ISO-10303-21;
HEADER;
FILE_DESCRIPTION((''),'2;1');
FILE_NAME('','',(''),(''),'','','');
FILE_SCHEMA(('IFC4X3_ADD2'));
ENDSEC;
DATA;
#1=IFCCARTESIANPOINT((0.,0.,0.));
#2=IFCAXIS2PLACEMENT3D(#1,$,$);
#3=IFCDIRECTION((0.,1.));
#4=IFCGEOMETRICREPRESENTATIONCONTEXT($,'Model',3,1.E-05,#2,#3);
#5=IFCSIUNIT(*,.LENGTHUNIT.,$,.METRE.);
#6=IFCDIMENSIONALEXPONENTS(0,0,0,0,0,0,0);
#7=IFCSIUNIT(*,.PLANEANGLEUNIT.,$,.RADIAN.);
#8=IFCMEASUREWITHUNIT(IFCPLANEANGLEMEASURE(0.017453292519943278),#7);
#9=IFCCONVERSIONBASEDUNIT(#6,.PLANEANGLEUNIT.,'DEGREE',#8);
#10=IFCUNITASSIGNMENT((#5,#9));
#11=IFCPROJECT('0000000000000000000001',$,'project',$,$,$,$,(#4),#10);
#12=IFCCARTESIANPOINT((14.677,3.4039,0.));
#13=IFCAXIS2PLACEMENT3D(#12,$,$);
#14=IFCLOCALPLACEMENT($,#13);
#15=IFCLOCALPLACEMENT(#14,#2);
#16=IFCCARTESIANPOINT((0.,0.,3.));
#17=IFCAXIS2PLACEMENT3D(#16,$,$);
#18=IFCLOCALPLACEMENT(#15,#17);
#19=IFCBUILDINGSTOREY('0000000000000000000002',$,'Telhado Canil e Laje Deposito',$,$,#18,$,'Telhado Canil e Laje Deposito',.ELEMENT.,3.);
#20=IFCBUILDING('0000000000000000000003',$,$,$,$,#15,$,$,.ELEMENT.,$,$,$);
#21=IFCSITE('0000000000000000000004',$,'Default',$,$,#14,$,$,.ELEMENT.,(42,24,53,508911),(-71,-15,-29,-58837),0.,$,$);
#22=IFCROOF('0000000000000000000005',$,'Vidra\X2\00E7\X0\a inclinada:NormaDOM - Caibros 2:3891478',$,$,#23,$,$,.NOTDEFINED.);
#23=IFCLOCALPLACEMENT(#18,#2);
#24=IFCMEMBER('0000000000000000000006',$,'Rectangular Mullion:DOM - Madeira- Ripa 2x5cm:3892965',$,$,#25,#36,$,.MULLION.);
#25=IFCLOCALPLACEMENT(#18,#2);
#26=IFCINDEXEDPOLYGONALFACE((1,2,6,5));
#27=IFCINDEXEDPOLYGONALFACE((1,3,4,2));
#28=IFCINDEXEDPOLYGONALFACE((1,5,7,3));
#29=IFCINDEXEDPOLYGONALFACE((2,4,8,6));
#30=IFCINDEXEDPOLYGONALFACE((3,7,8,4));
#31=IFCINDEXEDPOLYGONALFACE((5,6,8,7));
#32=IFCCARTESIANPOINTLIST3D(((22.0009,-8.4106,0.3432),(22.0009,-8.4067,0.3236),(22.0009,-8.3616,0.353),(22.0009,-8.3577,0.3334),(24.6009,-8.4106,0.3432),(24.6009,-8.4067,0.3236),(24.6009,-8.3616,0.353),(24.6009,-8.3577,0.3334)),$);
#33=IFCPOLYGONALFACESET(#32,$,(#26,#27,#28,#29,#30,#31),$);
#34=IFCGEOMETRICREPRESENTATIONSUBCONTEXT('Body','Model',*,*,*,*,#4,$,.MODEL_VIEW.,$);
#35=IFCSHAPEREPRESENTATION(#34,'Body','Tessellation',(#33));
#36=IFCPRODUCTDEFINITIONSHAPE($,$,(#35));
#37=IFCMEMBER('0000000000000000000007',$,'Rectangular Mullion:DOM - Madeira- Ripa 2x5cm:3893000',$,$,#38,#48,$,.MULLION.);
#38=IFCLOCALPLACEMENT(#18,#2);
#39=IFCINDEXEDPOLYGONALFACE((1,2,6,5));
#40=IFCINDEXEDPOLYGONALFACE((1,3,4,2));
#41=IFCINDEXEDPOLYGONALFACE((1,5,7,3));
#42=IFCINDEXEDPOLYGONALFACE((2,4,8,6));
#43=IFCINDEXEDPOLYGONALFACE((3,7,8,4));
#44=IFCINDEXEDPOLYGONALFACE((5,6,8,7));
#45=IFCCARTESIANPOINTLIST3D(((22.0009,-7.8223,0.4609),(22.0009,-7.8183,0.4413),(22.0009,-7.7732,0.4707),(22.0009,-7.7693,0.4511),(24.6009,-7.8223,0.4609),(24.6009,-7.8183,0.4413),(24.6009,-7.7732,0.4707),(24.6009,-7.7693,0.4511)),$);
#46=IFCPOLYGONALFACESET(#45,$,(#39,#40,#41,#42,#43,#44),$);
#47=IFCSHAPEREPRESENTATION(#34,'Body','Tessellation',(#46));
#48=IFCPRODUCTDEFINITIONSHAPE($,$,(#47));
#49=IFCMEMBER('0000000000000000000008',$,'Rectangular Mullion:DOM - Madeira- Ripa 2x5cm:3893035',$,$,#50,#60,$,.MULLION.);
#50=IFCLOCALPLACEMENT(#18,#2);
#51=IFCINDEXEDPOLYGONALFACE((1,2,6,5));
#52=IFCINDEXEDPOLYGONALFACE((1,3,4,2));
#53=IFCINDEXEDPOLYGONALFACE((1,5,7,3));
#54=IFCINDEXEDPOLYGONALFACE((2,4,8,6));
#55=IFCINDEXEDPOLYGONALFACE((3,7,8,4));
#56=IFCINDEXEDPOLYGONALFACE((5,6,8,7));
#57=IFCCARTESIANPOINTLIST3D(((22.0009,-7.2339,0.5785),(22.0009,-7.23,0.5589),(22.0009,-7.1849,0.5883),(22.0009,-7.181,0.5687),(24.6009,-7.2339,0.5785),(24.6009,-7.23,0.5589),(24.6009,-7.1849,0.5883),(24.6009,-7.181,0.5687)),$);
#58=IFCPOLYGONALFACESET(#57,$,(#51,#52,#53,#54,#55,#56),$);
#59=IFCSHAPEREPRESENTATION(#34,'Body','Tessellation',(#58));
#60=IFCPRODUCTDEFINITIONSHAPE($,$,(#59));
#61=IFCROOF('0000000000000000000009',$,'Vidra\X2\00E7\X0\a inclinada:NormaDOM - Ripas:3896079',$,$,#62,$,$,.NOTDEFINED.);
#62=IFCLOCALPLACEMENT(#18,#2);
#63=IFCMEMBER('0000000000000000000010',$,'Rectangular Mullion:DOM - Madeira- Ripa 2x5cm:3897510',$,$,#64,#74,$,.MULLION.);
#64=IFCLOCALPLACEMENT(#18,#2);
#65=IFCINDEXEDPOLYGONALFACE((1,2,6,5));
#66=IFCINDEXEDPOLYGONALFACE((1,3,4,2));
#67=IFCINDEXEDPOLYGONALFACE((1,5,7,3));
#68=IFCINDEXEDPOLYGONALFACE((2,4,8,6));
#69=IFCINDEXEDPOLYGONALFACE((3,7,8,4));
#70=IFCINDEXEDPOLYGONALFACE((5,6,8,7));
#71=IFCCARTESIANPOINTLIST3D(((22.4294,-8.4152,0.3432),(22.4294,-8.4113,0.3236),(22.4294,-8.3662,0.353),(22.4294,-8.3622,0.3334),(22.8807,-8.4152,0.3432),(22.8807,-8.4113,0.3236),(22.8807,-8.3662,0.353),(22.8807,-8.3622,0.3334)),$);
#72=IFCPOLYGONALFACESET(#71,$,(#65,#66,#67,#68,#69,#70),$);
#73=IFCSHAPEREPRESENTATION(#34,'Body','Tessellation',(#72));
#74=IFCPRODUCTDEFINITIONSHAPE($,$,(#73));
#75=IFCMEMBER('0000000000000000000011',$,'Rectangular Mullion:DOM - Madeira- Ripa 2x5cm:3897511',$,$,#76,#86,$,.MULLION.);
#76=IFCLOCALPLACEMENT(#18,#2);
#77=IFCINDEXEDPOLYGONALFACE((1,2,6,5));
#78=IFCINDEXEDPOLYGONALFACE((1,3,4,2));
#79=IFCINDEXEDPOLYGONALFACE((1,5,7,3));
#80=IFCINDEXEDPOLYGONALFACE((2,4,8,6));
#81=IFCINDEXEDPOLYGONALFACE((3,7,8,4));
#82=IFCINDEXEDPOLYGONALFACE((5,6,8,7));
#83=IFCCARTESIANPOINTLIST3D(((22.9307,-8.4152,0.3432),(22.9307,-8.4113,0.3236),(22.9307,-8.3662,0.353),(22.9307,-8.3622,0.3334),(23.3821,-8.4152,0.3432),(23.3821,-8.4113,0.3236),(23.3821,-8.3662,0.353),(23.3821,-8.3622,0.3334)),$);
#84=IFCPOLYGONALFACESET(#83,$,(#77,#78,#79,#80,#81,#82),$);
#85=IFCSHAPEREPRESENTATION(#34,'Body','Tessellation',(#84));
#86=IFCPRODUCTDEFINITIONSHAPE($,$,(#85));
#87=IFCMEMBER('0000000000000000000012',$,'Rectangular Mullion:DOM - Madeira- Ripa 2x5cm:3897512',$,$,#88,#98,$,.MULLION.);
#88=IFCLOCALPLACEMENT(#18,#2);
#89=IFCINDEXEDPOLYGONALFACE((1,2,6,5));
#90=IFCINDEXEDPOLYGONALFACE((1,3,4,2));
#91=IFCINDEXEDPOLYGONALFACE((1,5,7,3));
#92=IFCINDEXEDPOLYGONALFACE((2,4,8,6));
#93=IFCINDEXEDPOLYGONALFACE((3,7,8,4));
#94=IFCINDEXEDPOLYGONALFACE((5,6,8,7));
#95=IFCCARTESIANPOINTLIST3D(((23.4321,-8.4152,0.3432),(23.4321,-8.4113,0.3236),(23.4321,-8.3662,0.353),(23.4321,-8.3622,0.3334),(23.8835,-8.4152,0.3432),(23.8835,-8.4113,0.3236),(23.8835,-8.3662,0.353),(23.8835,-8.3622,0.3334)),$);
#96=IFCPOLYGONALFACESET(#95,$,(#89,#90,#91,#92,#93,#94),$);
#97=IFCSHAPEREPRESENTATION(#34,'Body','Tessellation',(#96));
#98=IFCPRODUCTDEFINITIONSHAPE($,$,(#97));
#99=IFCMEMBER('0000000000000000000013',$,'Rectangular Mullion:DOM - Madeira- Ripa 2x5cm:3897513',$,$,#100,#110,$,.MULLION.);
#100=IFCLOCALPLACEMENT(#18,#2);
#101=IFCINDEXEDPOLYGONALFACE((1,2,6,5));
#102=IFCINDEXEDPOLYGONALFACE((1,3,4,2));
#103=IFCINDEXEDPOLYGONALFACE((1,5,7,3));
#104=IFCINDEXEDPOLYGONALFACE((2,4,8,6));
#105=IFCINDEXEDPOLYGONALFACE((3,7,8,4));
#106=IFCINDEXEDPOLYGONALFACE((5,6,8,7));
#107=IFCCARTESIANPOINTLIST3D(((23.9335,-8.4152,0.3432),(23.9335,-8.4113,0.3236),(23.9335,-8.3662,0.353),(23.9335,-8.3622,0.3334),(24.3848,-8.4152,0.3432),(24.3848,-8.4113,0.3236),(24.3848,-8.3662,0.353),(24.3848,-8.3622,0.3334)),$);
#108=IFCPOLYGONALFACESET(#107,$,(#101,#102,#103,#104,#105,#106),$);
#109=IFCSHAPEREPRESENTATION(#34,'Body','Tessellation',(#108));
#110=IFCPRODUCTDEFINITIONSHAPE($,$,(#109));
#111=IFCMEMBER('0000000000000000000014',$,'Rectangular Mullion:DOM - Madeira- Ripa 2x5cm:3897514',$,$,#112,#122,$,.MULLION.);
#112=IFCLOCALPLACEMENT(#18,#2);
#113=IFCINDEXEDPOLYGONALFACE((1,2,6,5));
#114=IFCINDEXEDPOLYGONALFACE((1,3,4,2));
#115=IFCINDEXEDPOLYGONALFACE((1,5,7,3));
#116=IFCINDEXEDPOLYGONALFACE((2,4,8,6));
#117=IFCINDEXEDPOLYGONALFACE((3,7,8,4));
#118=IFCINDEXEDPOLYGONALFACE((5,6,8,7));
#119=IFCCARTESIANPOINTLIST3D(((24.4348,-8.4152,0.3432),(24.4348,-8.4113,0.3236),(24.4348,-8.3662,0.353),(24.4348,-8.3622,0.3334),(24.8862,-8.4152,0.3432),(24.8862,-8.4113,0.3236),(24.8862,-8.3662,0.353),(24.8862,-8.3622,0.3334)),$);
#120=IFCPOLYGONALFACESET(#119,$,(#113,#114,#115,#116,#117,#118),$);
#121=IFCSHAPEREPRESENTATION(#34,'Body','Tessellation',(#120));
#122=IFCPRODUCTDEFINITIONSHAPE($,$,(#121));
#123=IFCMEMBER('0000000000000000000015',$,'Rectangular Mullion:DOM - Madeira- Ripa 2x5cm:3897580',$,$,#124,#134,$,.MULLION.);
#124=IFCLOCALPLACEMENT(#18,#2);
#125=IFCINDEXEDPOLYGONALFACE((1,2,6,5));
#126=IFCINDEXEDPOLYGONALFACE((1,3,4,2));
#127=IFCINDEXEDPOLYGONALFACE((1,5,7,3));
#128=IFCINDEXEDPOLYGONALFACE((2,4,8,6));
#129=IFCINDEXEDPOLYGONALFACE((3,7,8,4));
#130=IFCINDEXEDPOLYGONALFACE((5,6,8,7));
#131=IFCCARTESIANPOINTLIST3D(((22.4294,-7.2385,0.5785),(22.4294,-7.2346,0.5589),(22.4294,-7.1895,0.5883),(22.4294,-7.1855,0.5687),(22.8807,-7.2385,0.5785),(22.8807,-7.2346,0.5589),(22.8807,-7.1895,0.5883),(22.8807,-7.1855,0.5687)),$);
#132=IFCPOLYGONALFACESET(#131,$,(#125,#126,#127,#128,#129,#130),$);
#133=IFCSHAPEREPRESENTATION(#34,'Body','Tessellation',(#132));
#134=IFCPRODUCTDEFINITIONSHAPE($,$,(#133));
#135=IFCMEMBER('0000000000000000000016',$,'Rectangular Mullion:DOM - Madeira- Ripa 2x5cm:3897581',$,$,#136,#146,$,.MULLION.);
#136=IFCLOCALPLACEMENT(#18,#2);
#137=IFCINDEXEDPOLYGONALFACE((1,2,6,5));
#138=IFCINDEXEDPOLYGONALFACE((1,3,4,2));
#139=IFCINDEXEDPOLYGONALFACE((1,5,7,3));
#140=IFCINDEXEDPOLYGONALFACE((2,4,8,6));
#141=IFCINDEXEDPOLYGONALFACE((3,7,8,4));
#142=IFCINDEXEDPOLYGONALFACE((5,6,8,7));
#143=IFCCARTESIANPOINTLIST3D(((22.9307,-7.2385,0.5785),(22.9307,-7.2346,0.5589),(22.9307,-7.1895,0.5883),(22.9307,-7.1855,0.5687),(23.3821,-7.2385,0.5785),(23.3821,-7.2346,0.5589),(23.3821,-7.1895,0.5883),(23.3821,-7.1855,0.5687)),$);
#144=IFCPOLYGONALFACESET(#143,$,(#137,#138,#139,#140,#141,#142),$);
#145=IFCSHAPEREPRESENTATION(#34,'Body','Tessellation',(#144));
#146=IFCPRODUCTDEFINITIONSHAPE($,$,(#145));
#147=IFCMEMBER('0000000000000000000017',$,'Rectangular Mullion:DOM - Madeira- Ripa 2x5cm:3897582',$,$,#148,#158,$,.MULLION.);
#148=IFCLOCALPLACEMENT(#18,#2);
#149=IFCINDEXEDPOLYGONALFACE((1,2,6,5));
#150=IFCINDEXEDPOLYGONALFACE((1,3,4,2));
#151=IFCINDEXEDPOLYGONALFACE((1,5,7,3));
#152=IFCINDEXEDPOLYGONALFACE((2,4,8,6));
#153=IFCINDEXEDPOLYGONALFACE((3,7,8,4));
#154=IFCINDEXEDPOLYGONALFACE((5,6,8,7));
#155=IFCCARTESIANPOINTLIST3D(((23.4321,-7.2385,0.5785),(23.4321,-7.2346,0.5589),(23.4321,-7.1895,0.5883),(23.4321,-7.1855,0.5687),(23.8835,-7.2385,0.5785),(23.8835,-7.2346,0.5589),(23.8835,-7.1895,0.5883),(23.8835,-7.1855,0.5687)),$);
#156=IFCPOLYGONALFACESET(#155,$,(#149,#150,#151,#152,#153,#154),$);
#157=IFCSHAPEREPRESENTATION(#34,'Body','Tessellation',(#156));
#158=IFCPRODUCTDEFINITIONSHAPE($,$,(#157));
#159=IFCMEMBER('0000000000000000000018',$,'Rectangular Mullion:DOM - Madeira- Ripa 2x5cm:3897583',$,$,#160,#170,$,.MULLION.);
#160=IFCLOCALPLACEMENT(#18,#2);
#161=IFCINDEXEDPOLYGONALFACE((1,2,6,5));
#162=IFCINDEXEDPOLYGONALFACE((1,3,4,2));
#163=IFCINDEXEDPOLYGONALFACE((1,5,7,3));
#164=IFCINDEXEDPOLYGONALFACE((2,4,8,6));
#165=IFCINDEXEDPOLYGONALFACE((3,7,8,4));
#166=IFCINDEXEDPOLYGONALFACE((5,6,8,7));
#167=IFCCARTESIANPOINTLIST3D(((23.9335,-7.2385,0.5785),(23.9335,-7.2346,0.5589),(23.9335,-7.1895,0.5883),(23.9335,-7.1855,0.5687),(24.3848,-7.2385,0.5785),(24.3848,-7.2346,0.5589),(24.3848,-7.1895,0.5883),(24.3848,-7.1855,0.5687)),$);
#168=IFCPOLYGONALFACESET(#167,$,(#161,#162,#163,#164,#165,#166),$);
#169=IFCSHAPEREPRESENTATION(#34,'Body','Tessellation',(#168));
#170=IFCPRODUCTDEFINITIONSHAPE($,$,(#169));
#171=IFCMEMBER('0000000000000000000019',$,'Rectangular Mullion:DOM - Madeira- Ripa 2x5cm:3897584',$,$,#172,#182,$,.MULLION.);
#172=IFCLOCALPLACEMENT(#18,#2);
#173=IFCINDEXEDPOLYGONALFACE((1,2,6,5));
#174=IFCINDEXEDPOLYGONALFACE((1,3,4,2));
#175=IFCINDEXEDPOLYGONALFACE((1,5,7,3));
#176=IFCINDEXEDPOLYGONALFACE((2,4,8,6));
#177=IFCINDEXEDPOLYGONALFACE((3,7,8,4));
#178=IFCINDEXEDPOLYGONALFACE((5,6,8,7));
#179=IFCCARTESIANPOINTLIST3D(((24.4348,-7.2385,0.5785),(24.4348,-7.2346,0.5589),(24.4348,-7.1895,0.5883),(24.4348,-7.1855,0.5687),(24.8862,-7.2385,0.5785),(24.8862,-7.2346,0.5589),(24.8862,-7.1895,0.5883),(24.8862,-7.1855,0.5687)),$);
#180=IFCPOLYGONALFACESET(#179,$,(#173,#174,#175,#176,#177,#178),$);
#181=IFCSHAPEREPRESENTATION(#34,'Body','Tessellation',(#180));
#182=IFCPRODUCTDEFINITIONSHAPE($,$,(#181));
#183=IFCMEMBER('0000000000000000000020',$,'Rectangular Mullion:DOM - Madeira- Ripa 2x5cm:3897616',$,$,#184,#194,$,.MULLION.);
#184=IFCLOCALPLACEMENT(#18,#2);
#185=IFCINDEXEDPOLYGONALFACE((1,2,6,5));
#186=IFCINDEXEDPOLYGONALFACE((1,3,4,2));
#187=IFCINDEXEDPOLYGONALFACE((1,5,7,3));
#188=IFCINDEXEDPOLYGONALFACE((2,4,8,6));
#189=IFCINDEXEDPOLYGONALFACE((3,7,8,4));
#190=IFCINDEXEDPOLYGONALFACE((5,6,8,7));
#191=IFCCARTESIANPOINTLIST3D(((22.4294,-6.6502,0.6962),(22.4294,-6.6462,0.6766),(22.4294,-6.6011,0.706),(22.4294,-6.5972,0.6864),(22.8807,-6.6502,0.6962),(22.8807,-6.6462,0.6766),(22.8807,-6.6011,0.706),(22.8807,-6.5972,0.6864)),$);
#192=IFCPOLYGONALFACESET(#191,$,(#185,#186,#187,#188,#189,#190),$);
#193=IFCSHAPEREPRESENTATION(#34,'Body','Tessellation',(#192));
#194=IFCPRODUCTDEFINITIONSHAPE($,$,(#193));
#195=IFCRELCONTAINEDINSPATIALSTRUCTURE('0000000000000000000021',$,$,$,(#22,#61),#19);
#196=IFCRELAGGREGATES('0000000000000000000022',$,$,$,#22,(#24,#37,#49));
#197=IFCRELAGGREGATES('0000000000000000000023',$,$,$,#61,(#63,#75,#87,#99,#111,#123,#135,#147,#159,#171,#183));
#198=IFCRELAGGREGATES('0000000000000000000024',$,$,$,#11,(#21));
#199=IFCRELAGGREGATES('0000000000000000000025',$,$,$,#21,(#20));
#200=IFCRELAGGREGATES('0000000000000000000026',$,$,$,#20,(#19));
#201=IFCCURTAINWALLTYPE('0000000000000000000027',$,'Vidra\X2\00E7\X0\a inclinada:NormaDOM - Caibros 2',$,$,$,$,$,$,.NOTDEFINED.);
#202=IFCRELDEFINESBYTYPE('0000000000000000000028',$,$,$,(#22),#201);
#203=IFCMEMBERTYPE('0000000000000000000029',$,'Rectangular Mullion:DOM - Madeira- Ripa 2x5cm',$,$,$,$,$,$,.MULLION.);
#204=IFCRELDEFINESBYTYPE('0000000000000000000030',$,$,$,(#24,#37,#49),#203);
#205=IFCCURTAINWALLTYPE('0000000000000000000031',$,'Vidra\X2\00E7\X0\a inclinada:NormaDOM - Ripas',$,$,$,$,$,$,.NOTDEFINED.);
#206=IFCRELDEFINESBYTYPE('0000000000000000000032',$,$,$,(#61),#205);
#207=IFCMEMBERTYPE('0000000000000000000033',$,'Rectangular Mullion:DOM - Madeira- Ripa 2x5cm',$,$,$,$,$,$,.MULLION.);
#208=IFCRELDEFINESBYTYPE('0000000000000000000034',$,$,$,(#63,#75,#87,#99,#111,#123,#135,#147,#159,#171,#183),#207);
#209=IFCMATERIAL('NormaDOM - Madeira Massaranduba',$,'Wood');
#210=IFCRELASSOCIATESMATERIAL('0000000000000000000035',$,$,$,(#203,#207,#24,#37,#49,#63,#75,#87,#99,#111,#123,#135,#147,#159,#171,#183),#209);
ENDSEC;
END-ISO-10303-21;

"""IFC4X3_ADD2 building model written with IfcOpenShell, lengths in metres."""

from ifc_helpers import new_model, entity, si_unit, converted_unit, direction, frame, origin, origin_2d_with_axis, place, context, subcontext, project, spatial, rectangle, extrude, source, transform, mapped, material, material_profile, profile_set, profile_usage, type_object, type_shapes, element, aggregate, save


model = new_model("IFC4X3_ADD2")

# Units and contexts
model_context = context("Model", 3, precision=1e-05, world=origin(), true_north=direction((0.0, 1.0)))
body_context = subcontext(model_context, "Body", "Model", "MODEL_VIEW")
ifc_project = project(units=[si_unit("LENGTHUNIT", "METRE"), converted_unit("PLANEANGLEUNIT", "DEGREE", entity("IfcPlaneAngleMeasure", 0.017453292519943278), si_unit("PLANEANGLEUNIT", "RADIAN"), dimensions=[0, 0, 0, 0, 0, 0, 0])], contexts=[model_context])

# Site, building, storey
site_placement = place(None, frame((14.677, 3.4039, 0.0)))
site = spatial("IfcSite", under=ifc_project, at=site_placement, Name="Default", CompositionType="ELEMENT", RefLatitude=(42, 24, 53, 508911), RefLongitude=(-71, -15, -29, -58837), RefElevation=0.0)
building_placement = place(site_placement, origin())
building = spatial("IfcBuilding", under=site, at=building_placement, CompositionType="ELEMENT")
storey_placement = place(building_placement, frame((0.0, 0.0, 3.0)))
storey = spatial("IfcBuildingStorey", under=building, at=storey_placement, Name="Telhado Canil e Laje Deposito", LongName="Telhado Canil e Laje Deposito", CompositionType="ELEMENT", Elevation=3.0)

# Roofs, members
curtain_wall_type_1 = type_object("IfcCurtainWallType", Name="Vidraça inclinada:NormaDOM - Caibros 2", PredefinedType="NOTDEFINED")
roof_1_placement = place(storey_placement, frame((0.0, 0.0, -3.0)))
roof_1 = element("IfcRoof", 1, at=roof_1_placement, inside=storey, type_object=curtain_wall_type_1, Name="Vidraça inclinada:NormaDOM - Caibros 2:3891478", PredefinedType="NOTDEFINED")
ifc_material = material(Name="NormaDOM - Madeira Massaranduba", Category="Wood")
ifc_material_profile_1 = material_profile(ifc_material, rectangle(XDim=0.05, YDim=0.02, at=origin_2d_with_axis()), Name="DOM - Madeira- Ripa 2x5cm")
ifc_profile_set_1 = profile_set([ifc_material_profile_1], Name="DOM - Madeira- Ripa 2x5cm")
ifc_profile_usage_1 = profile_usage(ifc_profile_set_1)
member_type_1 = type_object("IfcMemberType", Name="Rectangular Mullion:DOM - Madeira- Ripa 2x5cm", PredefinedType="MULLION", material=ifc_profile_set_1)
shared_shape_1 = source(origin(), body_context, "Body", "SweptSolid", [
    extrude(rectangle(XDim=0.05, YDim=0.02, at=origin_2d_with_axis()), frame((0.025, 0.01, -2.6), z_axis=(0.0, 0.0, 1.0), x_axis=(-1.0, 0.0, 0.0)), (0.0, 0.0, 1.0), 2.6),
])
type_shapes(member_type_1, [shared_shape_1])
member_1_placement = place(roof_1_placement, frame((22.0009, -8.4106, 3.3432), z_axis=(-1.0, 0.0, 0.0), x_axis=(0.0, 0.980581, 0.196116)))
member_1 = element("IfcMember", 2, at=member_1_placement, type_object=member_type_1, material=ifc_profile_usage_1, Name="Rectangular Mullion:DOM - Madeira- Ripa 2x5cm:3892965", PredefinedType="MULLION", context=body_context, shape_type="MappedRepresentation", body=[
    mapped(shared_shape_1, transform((0.0, 0.0, 0.0), scale=1.0)),
])
member_2_placement = place(roof_1_placement, frame((22.0009, -7.8223, 3.4609), z_axis=(-1.0, 0.0, 0.0), x_axis=(0.0, 0.980581, 0.196116)))
member_2 = element("IfcMember", 3, at=member_2_placement, type_object=member_type_1, material=ifc_profile_usage_1, Name="Rectangular Mullion:DOM - Madeira- Ripa 2x5cm:3893000", PredefinedType="MULLION", context=body_context, shape_type="MappedRepresentation", body=[
    mapped(shared_shape_1, transform((0.0, 0.0, 0.0), scale=1.0)),
])
member_3_placement = place(roof_1_placement, frame((22.0009, -7.2339, 3.5785), z_axis=(-1.0, 0.0, 0.0), x_axis=(0.0, 0.980581, 0.196116)))
member_3 = element("IfcMember", 4, at=member_3_placement, type_object=member_type_1, material=ifc_profile_usage_1, Name="Rectangular Mullion:DOM - Madeira- Ripa 2x5cm:3893035", PredefinedType="MULLION", context=body_context, shape_type="MappedRepresentation", body=[
    mapped(shared_shape_1, transform((0.0, 0.0, 0.0), scale=1.0)),
])
aggregate(roof_1, [member_1, member_2, member_3])
curtain_wall_type_2 = type_object("IfcCurtainWallType", Name="Vidraça inclinada:NormaDOM - Ripas", PredefinedType="NOTDEFINED")
roof_2_placement = place(storey_placement, frame((0.0, 0.0, -3.0)))
roof_2 = element("IfcRoof", 5, at=roof_2_placement, inside=storey, type_object=curtain_wall_type_2, Name="Vidraça inclinada:NormaDOM - Ripas:3896079", PredefinedType="NOTDEFINED")
member_type_2 = type_object("IfcMemberType", Name="Rectangular Mullion:DOM - Madeira- Ripa 2x5cm", PredefinedType="MULLION", material=ifc_profile_set_1)
shared_shape_2 = source(origin(), body_context, "Body", "SweptSolid", [
    extrude(rectangle(XDim=0.05, YDim=0.02, at=origin_2d_with_axis()), frame((0.025, 0.01, -0.4514), z_axis=(0.0, 0.0, 1.0), x_axis=(-1.0, 0.0, 0.0)), (0.0, 0.0, 1.0), 0.4514),
])
type_shapes(member_type_2, [shared_shape_2])
member_4_placement = place(roof_2_placement, frame((22.4294, -8.4152, 3.3432), z_axis=(-1.0, 0.0, 0.0), x_axis=(0.0, 0.980581, 0.196116)))
member_4 = element("IfcMember", 6, at=member_4_placement, type_object=member_type_2, material=ifc_profile_usage_1, Name="Rectangular Mullion:DOM - Madeira- Ripa 2x5cm:3897510", PredefinedType="MULLION", context=body_context, shape_type="MappedRepresentation", body=[
    mapped(shared_shape_2, transform((0.0, 0.0, 0.0), scale=1.0)),
])
member_5_placement = place(roof_2_placement, frame((22.9307, -8.4152, 3.3432), z_axis=(-1.0, 0.0, 0.0), x_axis=(0.0, 0.980581, 0.196116)))
member_5 = element("IfcMember", 7, at=member_5_placement, type_object=member_type_2, material=ifc_profile_usage_1, Name="Rectangular Mullion:DOM - Madeira- Ripa 2x5cm:3897511", PredefinedType="MULLION", context=body_context, shape_type="MappedRepresentation", body=[
    mapped(shared_shape_2, transform((0.0, 0.0, 0.0), scale=1.0)),
])
member_6_placement = place(roof_2_placement, frame((23.4321, -8.4152, 3.3432), z_axis=(-1.0, 0.0, 0.0), x_axis=(0.0, 0.980581, 0.196116)))
member_6 = element("IfcMember", 8, at=member_6_placement, type_object=member_type_2, material=ifc_profile_usage_1, Name="Rectangular Mullion:DOM - Madeira- Ripa 2x5cm:3897512", PredefinedType="MULLION", context=body_context, shape_type="MappedRepresentation", body=[
    mapped(shared_shape_2, transform((0.0, 0.0, 0.0), scale=1.0)),
])
member_7_placement = place(roof_2_placement, frame((23.9335, -8.4152, 3.3432), z_axis=(-1.0, 0.0, 0.0), x_axis=(0.0, 0.980581, 0.196116)))
member_7 = element("IfcMember", 9, at=member_7_placement, type_object=member_type_2, material=ifc_profile_usage_1, Name="Rectangular Mullion:DOM - Madeira- Ripa 2x5cm:3897513", PredefinedType="MULLION", context=body_context, shape_type="MappedRepresentation", body=[
    mapped(shared_shape_2, transform((0.0, 0.0, 0.0), scale=1.0)),
])
member_8_placement = place(roof_2_placement, frame((24.4348, -8.4152, 3.3432), z_axis=(-1.0, 0.0, 0.0), x_axis=(0.0, 0.980581, 0.196116)))
member_8 = element("IfcMember", 10, at=member_8_placement, type_object=member_type_2, material=ifc_profile_usage_1, Name="Rectangular Mullion:DOM - Madeira- Ripa 2x5cm:3897514", PredefinedType="MULLION", context=body_context, shape_type="MappedRepresentation", body=[
    mapped(shared_shape_2, transform((0.0, 0.0, 0.0), scale=1.0)),
])
member_9_placement = place(roof_2_placement, frame((22.4294, -7.2385, 3.5785), z_axis=(-1.0, 0.0, 0.0), x_axis=(0.0, 0.980581, 0.196116)))
member_9 = element("IfcMember", 11, at=member_9_placement, type_object=member_type_2, material=ifc_profile_usage_1, Name="Rectangular Mullion:DOM - Madeira- Ripa 2x5cm:3897580", PredefinedType="MULLION", context=body_context, shape_type="MappedRepresentation", body=[
    mapped(shared_shape_2, transform((0.0, 0.0, 0.0), scale=1.0)),
])
member_10_placement = place(roof_2_placement, frame((22.9307, -7.2385, 3.5785), z_axis=(-1.0, 0.0, 0.0), x_axis=(0.0, 0.980581, 0.196116)))
member_10 = element("IfcMember", 12, at=member_10_placement, type_object=member_type_2, material=ifc_profile_usage_1, Name="Rectangular Mullion:DOM - Madeira- Ripa 2x5cm:3897581", PredefinedType="MULLION", context=body_context, shape_type="MappedRepresentation", body=[
    mapped(shared_shape_2, transform((0.0, 0.0, 0.0), scale=1.0)),
])
member_11_placement = place(roof_2_placement, frame((23.4321, -7.2385, 3.5785), z_axis=(-1.0, 0.0, 0.0), x_axis=(0.0, 0.980581, 0.196116)))
member_11 = element("IfcMember", 13, at=member_11_placement, type_object=member_type_2, material=ifc_profile_usage_1, Name="Rectangular Mullion:DOM - Madeira- Ripa 2x5cm:3897582", PredefinedType="MULLION", context=body_context, shape_type="MappedRepresentation", body=[
    mapped(shared_shape_2, transform((0.0, 0.0, 0.0), scale=1.0)),
])
member_12_placement = place(roof_2_placement, frame((23.9335, -7.2385, 3.5785), z_axis=(-1.0, 0.0, 0.0), x_axis=(0.0, 0.980581, 0.196116)))
member_12 = element("IfcMember", 14, at=member_12_placement, type_object=member_type_2, material=ifc_profile_usage_1, Name="Rectangular Mullion:DOM - Madeira- Ripa 2x5cm:3897583", PredefinedType="MULLION", context=body_context, shape_type="MappedRepresentation", body=[
    mapped(shared_shape_2, transform((0.0, 0.0, 0.0), scale=1.0)),
])
member_13_placement = place(roof_2_placement, frame((24.4348, -7.2385, 3.5785), z_axis=(-1.0, 0.0, 0.0), x_axis=(0.0, 0.980581, 0.196116)))
member_13 = element("IfcMember", 15, at=member_13_placement, type_object=member_type_2, material=ifc_profile_usage_1, Name="Rectangular Mullion:DOM - Madeira- Ripa 2x5cm:3897584", PredefinedType="MULLION", context=body_context, shape_type="MappedRepresentation", body=[
    mapped(shared_shape_2, transform((0.0, 0.0, 0.0), scale=1.0)),
])
member_14_placement = place(roof_2_placement, frame((22.4294, -6.6502, 3.6962), z_axis=(-1.0, 0.0, 0.0), x_axis=(0.0, 0.980581, 0.196116)))
member_14 = element("IfcMember", 16, at=member_14_placement, type_object=member_type_2, material=ifc_profile_usage_1, Name="Rectangular Mullion:DOM - Madeira- Ripa 2x5cm:3897616", PredefinedType="MULLION", context=body_context, shape_type="MappedRepresentation", body=[
    mapped(shared_shape_2, transform((0.0, 0.0, 0.0), scale=1.0)),
])
aggregate(roof_2, [member_4, member_5, member_6, member_7, member_8, member_9, member_10, member_11, member_12, member_13, member_14])

save(model, "model.ifc")
